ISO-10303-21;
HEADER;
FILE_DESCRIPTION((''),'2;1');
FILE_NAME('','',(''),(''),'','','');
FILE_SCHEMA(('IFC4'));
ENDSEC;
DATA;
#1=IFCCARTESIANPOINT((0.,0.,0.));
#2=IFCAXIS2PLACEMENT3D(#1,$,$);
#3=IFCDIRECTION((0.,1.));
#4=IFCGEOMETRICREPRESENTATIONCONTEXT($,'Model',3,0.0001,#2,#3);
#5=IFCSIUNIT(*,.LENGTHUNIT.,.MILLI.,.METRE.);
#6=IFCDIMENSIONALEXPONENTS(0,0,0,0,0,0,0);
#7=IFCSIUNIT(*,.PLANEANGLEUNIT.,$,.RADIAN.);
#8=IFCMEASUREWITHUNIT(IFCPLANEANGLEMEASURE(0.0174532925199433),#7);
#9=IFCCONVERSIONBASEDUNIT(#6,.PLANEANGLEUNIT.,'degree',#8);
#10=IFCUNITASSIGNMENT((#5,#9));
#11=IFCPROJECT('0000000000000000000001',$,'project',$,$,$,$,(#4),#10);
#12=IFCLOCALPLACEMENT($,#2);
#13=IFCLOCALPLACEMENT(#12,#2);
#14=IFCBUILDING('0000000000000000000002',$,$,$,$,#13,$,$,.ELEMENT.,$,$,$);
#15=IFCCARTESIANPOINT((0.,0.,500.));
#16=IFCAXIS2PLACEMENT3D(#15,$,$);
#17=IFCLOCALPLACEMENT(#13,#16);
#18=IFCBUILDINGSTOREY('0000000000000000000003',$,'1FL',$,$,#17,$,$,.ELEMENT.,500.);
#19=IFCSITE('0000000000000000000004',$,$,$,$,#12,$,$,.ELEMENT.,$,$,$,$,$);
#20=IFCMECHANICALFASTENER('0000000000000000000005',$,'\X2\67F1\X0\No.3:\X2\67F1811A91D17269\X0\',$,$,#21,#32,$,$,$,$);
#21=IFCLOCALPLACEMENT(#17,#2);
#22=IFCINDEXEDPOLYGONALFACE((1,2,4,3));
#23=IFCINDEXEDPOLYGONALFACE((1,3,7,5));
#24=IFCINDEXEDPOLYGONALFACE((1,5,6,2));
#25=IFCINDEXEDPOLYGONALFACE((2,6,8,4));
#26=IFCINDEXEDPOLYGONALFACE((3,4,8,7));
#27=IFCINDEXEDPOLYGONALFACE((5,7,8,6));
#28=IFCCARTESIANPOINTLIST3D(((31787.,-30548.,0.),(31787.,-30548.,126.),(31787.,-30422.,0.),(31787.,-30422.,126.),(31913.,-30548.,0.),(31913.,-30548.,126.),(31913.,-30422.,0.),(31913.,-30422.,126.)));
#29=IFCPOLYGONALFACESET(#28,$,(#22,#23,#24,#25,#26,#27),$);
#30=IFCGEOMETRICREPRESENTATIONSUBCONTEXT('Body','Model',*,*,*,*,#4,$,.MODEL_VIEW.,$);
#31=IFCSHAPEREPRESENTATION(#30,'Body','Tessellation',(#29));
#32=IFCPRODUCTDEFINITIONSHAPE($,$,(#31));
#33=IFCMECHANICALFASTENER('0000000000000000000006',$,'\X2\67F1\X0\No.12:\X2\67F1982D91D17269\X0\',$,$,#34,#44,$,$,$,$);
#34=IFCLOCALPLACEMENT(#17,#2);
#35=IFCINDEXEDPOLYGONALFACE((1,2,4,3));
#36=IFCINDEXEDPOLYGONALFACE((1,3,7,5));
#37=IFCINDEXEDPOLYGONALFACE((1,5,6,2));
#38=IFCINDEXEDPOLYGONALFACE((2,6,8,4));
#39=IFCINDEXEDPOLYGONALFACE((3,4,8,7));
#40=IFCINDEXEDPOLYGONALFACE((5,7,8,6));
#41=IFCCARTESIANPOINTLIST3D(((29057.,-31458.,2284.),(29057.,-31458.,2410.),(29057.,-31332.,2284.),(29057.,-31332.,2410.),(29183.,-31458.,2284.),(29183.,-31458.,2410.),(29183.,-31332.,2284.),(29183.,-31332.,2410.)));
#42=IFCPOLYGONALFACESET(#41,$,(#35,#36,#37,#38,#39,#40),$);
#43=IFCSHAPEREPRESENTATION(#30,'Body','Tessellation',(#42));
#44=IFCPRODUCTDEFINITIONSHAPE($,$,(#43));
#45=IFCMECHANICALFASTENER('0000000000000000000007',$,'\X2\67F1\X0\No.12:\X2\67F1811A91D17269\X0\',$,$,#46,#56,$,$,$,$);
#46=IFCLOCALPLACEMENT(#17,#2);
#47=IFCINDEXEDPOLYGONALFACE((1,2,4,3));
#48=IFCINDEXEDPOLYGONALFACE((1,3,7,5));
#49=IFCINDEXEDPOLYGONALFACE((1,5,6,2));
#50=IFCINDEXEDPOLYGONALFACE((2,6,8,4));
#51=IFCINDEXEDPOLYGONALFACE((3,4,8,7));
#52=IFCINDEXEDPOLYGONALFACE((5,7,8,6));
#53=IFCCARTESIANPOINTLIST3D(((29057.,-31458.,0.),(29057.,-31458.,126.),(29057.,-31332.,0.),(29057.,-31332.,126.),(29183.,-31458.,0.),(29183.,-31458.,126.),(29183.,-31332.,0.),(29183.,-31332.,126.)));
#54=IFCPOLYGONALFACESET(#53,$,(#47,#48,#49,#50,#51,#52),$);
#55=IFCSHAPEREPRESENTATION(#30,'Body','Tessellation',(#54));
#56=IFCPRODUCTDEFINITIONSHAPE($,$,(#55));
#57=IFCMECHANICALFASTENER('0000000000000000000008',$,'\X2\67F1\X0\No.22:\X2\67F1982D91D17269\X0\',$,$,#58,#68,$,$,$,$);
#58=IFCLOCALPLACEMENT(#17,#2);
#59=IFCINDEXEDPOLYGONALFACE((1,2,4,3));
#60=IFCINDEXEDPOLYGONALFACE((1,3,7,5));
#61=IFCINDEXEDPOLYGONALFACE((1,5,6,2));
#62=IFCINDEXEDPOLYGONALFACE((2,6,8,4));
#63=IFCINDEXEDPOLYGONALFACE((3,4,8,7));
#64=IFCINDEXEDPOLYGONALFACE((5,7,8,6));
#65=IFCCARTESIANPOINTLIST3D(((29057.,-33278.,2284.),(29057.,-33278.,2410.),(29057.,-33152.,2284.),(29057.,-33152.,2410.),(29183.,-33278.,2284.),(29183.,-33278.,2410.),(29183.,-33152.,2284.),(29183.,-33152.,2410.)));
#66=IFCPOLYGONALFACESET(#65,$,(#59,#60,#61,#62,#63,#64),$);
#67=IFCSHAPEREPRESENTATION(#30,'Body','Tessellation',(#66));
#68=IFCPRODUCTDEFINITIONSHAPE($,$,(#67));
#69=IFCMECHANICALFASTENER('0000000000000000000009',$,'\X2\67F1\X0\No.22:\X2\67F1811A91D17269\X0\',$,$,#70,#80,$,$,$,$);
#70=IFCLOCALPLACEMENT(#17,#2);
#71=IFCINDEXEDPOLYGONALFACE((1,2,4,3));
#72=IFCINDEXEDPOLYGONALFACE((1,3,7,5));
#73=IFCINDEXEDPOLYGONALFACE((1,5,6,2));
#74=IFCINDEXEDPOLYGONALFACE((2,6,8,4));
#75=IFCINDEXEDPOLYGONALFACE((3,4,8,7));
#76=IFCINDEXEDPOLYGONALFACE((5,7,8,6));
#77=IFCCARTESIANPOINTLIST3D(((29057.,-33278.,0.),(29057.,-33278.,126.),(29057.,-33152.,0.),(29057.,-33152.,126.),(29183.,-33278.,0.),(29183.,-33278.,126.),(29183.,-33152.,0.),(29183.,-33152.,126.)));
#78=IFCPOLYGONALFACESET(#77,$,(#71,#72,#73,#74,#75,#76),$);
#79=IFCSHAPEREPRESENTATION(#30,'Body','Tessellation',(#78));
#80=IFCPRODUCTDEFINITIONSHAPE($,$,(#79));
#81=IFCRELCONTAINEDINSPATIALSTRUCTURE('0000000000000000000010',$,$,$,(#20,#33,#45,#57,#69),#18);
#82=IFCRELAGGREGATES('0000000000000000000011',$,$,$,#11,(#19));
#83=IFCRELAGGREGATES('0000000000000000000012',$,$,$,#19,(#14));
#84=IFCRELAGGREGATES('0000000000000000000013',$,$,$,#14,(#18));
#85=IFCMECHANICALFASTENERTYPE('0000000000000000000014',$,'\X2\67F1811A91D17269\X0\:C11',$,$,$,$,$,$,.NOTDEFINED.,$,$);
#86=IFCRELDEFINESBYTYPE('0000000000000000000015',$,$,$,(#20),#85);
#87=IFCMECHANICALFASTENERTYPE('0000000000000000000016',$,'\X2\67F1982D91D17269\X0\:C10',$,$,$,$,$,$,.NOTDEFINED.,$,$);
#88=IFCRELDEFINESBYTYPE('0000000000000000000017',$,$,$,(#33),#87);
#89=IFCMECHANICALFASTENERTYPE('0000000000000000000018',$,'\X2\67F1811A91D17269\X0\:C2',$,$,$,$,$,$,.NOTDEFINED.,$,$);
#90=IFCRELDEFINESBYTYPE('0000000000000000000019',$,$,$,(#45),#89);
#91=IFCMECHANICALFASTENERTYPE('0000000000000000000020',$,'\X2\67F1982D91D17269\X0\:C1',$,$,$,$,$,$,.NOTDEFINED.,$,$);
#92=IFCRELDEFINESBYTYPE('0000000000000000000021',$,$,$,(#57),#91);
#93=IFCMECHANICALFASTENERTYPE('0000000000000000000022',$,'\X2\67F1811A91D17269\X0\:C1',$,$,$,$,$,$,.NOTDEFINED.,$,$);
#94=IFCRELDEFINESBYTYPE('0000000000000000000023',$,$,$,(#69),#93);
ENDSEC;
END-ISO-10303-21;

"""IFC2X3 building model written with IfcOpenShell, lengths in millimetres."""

from ifc_helpers import new_model, entity, si_unit, converted_unit, direction, frame, origin, origin_with_axes, origin_2d, place, context, subcontext, project, spatial, rectangle, extrude, type_object, element, save


model = new_model("IFC2X3")

# Units and contexts
model_context = context("Model", 3, precision=0.0001, world=origin(), true_north=direction((0.0, 1.0)))
body_context = subcontext(model_context, "Body", "Model", "MODEL_VIEW")
ifc_project = project(units=[si_unit("LENGTHUNIT", "METRE", prefix="MILLI"), converted_unit("PLANEANGLEUNIT", "degree", entity("IfcPlaneAngleMeasure", 0.0174532925199433), si_unit("PLANEANGLEUNIT", "RADIAN"), dimensions=[0, 0, 0, 0, 0, 0, 0])], contexts=[model_context])

# Site, building, storey
site_placement = place(None, origin())
site = spatial("IfcSite", under=ifc_project, at=site_placement, CompositionType="ELEMENT")
building_placement = place(site_placement, origin())
building = spatial("IfcBuilding", under=site, at=building_placement, CompositionType="ELEMENT")
storey_placement = place(building_placement, frame((0.0, 0.0, 500.0)))
storey = spatial("IfcBuildingStorey", under=building, at=storey_placement, Name="1FL", CompositionType="ELEMENT", Elevation=500.0)

# Mechanical fasteners
mechanical_fastener_type_1 = type_object("IfcMechanicalFastenerType", Name="柱脚金物:C11")
mechanical_fastener_1_placement = place(storey_placement, frame((31850.0, -30485.0, 0.0)))
element("IfcMechanicalFastener", 1, at=mechanical_fastener_1_placement, inside=storey, type_object=mechanical_fastener_type_1, Name="柱No.3:柱脚金物", context=body_context, shape_type="SweptSolid", body=[
    extrude(rectangle(XDim=126.0, YDim=126.0, at=origin_2d()), origin_with_axes(), (0.0, 0.0, 1.0), 126.0),
])
mechanical_fastener_type_2 = type_object("IfcMechanicalFastenerType", Name="柱頭金物:C10")
mechanical_fastener_2_placement = place(storey_placement, frame((29120.0, -31395.0, 2284.0)))
element("IfcMechanicalFastener", 2, at=mechanical_fastener_2_placement, inside=storey, type_object=mechanical_fastener_type_2, Name="柱No.12:柱頭金物", context=body_context, shape_type="SweptSolid", body=[
    extrude(rectangle(XDim=126.0, YDim=126.0, at=origin_2d()), origin_with_axes(), (0.0, 0.0, 1.0), 126.0),
])
mechanical_fastener_type_3 = type_object("IfcMechanicalFastenerType", Name="柱脚金物:C2")
mechanical_fastener_3_placement = place(storey_placement, frame((29120.0, -31395.0, 0.0)))
element("IfcMechanicalFastener", 3, at=mechanical_fastener_3_placement, inside=storey, type_object=mechanical_fastener_type_3, Name="柱No.12:柱脚金物", context=body_context, shape_type="SweptSolid", body=[
    extrude(rectangle(XDim=126.0, YDim=126.0, at=origin_2d()), origin_with_axes(), (0.0, 0.0, 1.0), 126.0),
])
mechanical_fastener_type_4 = type_object("IfcMechanicalFastenerType", Name="柱頭金物:C1")
mechanical_fastener_4_placement = place(storey_placement, frame((29120.0, -33215.0, 2284.0)))
element("IfcMechanicalFastener", 4, at=mechanical_fastener_4_placement, inside=storey, type_object=mechanical_fastener_type_4, Name="柱No.22:柱頭金物", context=body_context, shape_type="SweptSolid", body=[
    extrude(rectangle(XDim=126.0, YDim=126.0, at=origin_2d()), origin_with_axes(), (0.0, 0.0, 1.0), 126.0),
])
mechanical_fastener_type_5 = type_object("IfcMechanicalFastenerType", Name="柱脚金物:C1")
mechanical_fastener_5_placement = place(storey_placement, frame((29120.0, -33215.0, 0.0)))
element("IfcMechanicalFastener", 5, at=mechanical_fastener_5_placement, inside=storey, type_object=mechanical_fastener_type_5, Name="柱No.22:柱脚金物", context=body_context, shape_type="SweptSolid", body=[
    extrude(rectangle(XDim=126.0, YDim=126.0, at=origin_2d()), origin_with_axes(), (0.0, 0.0, 1.0), 126.0),
])

save(model, "model.ifc")
